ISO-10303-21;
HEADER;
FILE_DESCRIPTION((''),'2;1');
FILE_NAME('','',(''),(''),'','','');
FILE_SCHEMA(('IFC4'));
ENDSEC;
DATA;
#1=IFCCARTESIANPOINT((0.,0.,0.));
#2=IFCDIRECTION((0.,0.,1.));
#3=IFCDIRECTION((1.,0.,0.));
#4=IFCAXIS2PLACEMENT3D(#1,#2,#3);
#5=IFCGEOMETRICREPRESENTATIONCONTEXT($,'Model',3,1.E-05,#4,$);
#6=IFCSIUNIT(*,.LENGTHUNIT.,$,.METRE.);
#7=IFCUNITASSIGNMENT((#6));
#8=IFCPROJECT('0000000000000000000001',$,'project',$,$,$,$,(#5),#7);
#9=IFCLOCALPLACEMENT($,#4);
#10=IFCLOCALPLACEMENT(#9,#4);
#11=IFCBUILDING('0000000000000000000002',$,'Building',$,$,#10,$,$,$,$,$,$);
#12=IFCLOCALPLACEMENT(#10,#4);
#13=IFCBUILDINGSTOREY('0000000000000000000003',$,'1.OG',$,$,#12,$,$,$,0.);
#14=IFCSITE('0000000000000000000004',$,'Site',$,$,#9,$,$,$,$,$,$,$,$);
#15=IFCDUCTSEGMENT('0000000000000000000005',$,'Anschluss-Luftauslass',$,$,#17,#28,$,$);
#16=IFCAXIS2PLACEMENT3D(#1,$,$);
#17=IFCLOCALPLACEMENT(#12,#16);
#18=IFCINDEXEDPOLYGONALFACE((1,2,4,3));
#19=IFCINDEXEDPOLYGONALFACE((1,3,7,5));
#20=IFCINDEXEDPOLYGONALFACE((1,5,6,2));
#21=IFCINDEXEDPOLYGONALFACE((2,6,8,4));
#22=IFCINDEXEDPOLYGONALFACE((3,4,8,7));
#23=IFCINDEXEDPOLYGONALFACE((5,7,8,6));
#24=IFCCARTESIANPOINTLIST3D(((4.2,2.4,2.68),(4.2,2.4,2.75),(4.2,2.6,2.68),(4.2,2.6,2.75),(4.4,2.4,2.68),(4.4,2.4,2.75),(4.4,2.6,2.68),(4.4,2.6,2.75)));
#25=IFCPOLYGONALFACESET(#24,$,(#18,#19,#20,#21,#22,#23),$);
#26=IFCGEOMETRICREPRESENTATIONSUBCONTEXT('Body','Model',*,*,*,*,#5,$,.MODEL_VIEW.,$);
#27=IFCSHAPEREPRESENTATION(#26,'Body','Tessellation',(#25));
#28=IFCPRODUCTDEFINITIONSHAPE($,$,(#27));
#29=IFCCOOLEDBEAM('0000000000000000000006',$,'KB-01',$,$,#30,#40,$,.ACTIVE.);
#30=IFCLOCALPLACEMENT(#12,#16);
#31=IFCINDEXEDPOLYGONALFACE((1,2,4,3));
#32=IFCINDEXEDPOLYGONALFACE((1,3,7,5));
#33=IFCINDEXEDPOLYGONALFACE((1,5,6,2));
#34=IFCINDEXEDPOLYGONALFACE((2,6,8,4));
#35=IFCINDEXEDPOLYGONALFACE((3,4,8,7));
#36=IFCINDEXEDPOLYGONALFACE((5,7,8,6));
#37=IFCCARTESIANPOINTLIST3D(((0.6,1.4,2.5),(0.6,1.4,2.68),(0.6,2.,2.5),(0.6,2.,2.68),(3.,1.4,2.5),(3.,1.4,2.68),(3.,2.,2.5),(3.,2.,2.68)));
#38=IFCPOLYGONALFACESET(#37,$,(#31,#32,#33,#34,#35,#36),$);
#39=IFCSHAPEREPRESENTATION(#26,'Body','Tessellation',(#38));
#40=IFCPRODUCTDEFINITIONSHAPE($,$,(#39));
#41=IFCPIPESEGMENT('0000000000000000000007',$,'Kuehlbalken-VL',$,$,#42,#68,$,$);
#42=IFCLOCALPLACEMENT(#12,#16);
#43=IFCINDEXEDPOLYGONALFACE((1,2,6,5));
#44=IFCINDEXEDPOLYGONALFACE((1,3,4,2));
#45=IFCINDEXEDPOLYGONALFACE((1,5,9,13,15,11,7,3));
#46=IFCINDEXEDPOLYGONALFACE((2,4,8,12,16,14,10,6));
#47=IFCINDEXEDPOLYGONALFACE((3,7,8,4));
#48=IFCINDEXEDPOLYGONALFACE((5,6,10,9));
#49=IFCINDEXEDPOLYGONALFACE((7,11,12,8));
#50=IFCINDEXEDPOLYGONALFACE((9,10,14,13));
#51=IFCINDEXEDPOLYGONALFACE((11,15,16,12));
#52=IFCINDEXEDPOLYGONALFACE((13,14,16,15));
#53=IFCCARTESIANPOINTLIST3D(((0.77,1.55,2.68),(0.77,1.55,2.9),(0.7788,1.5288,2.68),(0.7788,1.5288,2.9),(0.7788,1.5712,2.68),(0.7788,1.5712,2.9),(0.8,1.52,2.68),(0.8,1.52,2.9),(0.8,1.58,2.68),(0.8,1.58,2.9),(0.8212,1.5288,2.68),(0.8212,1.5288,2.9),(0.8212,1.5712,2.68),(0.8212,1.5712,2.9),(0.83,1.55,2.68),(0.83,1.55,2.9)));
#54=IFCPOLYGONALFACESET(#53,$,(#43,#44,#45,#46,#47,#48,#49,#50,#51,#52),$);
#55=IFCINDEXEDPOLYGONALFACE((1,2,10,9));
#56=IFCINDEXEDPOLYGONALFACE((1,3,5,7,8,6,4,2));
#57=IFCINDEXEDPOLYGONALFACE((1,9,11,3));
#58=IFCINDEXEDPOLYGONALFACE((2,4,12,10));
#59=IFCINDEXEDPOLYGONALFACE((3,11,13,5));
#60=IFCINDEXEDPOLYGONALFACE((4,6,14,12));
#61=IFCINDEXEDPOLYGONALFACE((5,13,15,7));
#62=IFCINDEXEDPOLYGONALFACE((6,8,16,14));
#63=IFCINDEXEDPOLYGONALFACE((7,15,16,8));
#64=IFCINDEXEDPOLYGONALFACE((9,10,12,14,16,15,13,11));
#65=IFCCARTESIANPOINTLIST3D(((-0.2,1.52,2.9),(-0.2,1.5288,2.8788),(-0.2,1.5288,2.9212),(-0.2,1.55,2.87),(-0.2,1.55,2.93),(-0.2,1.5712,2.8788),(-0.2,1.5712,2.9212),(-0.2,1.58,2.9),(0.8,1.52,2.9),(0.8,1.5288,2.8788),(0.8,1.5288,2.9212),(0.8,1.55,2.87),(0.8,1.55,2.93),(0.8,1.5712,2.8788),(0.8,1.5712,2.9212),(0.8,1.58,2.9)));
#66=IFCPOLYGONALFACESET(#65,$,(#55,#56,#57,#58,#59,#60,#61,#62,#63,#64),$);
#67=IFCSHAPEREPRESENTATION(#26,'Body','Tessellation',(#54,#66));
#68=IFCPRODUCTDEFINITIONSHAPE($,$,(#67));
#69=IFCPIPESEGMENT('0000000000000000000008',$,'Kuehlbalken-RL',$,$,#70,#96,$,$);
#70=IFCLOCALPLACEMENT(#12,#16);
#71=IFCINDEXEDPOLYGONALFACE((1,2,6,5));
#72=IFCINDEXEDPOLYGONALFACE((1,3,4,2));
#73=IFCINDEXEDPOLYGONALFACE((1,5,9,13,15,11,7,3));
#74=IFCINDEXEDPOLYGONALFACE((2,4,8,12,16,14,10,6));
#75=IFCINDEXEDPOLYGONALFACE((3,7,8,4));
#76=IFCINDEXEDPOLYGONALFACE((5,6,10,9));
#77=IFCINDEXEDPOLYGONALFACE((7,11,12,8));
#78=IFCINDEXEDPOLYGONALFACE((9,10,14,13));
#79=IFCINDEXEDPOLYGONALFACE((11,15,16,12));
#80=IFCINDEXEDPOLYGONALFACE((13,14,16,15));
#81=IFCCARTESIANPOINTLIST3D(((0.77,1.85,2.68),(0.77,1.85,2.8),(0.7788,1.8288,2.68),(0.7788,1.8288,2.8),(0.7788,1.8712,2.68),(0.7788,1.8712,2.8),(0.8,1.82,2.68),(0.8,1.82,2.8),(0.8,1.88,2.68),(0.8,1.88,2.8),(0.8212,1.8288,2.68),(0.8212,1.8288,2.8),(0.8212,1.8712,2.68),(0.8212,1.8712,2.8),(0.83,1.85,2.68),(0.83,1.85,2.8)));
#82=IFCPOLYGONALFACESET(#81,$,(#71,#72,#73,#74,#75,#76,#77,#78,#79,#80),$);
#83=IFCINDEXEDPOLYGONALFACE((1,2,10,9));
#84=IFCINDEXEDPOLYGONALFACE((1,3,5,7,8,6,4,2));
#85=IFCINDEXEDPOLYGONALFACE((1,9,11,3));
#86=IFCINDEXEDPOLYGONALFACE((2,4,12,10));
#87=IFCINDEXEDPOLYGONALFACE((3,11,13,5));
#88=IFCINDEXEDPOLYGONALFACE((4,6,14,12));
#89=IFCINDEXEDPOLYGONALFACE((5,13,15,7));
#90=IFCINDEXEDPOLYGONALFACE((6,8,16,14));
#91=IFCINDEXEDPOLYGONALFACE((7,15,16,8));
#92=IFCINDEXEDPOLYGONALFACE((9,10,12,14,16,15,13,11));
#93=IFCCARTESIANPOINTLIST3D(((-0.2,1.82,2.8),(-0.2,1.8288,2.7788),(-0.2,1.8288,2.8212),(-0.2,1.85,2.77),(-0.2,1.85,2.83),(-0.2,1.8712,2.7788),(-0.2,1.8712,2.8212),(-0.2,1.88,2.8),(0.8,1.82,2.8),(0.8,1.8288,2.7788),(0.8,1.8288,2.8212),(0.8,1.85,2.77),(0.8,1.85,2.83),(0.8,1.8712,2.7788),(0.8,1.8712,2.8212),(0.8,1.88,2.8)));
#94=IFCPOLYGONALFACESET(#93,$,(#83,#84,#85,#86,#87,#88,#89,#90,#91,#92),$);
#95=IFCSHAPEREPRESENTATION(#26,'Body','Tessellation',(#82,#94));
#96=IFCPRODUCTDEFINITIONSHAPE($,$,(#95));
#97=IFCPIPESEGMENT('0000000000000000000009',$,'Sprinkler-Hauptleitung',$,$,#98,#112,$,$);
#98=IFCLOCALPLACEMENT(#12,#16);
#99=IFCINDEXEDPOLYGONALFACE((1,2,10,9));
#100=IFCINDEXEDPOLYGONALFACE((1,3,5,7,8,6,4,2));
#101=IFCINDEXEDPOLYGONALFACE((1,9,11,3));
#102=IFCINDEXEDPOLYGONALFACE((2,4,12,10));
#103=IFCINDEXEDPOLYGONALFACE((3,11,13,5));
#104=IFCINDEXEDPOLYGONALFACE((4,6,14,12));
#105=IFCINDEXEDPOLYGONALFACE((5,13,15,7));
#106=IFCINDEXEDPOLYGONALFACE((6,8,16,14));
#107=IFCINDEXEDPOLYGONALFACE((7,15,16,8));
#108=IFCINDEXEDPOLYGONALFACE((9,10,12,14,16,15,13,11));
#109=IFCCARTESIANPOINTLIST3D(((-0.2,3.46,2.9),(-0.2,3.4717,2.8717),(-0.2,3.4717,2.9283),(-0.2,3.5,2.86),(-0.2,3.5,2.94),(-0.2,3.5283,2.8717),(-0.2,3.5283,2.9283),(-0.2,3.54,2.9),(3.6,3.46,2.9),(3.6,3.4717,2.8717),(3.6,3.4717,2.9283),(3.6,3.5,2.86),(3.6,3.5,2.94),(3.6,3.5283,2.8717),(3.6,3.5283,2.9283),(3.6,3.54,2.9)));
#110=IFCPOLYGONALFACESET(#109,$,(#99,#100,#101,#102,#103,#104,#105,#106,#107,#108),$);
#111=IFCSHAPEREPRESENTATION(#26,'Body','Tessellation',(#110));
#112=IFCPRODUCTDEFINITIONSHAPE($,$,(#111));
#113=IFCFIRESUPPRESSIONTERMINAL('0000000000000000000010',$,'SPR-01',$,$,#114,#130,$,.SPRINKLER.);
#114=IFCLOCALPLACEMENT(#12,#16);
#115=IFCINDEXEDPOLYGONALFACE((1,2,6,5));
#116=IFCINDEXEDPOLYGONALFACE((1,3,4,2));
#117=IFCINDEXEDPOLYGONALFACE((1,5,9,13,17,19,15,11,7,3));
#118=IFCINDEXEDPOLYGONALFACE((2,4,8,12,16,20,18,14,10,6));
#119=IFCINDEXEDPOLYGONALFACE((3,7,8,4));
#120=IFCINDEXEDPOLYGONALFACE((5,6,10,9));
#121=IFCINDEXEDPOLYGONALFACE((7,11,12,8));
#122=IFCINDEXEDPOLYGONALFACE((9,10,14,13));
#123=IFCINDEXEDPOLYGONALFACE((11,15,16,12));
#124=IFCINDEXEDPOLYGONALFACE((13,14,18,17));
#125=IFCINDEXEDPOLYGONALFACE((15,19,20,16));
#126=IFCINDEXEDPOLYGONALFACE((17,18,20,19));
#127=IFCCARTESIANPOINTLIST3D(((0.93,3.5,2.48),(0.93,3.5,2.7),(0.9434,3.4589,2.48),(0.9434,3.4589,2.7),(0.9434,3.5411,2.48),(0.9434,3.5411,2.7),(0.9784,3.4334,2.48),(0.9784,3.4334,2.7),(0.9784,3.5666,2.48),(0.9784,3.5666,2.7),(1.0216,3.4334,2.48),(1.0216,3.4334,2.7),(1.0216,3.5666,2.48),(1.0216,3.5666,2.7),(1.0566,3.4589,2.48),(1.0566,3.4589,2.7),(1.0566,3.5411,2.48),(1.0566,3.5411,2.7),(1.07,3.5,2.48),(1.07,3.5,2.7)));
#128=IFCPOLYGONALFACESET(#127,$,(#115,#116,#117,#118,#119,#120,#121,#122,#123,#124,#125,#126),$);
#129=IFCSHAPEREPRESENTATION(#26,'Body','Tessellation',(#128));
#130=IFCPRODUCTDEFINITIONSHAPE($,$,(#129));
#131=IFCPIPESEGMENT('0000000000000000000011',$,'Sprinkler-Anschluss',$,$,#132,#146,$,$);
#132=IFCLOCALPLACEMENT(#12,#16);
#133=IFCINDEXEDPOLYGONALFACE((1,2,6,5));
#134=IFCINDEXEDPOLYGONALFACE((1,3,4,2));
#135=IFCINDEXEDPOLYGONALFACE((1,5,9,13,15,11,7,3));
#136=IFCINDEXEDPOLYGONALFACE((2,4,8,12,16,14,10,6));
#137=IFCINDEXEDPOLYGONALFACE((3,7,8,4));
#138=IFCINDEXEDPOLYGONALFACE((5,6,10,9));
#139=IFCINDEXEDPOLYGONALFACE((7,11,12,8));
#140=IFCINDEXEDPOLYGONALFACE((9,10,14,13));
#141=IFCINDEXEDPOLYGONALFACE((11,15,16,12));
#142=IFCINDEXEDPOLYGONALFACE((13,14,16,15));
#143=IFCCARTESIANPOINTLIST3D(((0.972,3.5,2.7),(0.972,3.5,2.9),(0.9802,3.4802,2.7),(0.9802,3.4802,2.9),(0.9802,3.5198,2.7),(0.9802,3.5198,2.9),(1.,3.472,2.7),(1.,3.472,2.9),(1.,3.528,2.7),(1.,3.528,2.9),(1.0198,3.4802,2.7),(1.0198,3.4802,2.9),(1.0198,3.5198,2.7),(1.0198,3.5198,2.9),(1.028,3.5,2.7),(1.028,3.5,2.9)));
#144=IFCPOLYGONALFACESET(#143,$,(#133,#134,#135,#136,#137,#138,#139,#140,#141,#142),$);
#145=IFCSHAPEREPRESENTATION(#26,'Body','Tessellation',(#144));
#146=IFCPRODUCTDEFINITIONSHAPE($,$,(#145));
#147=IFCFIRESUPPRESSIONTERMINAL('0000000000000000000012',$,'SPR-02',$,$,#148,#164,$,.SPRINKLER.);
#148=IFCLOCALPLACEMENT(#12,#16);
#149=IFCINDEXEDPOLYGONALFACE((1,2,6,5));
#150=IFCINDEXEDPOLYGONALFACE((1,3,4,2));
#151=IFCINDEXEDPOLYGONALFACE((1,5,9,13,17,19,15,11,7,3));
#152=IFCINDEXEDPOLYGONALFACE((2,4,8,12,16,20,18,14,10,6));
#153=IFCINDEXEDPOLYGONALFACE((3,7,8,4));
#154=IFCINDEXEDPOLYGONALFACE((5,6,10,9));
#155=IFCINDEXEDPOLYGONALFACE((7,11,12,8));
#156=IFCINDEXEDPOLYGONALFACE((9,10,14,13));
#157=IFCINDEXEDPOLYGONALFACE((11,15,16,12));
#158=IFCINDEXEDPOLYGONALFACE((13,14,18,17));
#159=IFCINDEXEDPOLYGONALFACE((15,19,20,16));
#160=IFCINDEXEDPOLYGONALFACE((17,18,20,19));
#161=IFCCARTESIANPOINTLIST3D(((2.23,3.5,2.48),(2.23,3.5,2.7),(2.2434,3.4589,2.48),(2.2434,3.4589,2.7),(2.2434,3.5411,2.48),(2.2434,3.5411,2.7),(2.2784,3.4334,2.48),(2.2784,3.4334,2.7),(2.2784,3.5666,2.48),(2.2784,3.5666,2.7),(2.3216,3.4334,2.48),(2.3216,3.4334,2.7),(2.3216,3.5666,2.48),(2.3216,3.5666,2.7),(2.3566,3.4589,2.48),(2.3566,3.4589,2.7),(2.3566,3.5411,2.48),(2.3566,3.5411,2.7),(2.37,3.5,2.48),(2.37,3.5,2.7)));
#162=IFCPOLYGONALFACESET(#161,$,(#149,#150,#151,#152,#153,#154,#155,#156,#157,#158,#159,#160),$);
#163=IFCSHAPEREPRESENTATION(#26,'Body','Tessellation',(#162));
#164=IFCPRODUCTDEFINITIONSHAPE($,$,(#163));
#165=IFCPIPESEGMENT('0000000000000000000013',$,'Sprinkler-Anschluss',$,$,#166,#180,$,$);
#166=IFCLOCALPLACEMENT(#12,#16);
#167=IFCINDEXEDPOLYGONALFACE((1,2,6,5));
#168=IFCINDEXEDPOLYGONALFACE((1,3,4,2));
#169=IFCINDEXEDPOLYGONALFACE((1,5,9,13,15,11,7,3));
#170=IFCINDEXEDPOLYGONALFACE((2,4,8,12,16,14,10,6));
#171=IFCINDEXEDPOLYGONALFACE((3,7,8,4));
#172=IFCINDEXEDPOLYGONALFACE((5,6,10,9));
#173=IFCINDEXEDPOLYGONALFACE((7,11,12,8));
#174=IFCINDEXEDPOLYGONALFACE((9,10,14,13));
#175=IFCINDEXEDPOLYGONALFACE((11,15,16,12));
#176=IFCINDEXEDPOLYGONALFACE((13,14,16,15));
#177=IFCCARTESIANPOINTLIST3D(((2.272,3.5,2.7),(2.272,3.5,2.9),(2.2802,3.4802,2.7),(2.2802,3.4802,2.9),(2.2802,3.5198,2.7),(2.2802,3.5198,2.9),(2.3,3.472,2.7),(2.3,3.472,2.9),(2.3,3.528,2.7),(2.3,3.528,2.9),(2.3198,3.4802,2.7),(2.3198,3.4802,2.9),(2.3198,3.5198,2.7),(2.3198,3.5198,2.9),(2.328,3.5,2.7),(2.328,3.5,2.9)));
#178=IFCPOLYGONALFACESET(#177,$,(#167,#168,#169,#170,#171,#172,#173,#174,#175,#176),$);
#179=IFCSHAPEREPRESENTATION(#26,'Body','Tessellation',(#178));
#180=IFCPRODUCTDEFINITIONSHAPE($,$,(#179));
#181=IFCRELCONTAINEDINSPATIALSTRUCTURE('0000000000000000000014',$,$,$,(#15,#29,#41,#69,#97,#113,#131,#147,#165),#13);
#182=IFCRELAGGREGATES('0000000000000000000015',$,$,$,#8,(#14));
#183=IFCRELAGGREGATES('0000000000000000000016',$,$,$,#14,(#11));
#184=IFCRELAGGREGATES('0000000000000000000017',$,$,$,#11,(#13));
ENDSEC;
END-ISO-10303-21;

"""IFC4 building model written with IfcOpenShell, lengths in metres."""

from ifc_helpers import new_model, si_unit, frame, origin_with_axes, place, context, subcontext, project, spatial, polyline, outline, extrude, element, save


model = new_model("IFC4")

# Units and contexts
model_context = context("Model", 3, precision=1e-05, world=origin_with_axes())
body_context = subcontext(model_context, "Body", "Model", "MODEL_VIEW")
ifc_project = project(units=[si_unit("LENGTHUNIT", "METRE")], contexts=[model_context])

# Site, building, storey
site_placement = place(None, origin_with_axes())
site = spatial("IfcSite", under=ifc_project, at=site_placement, Name="Site")
building_placement = place(site_placement, origin_with_axes())
building = spatial("IfcBuilding", under=site, at=building_placement, Name="Building")
storey_placement = place(building_placement, origin_with_axes())
storey = spatial("IfcBuildingStorey", under=building, at=storey_placement, Name="1.OG", Elevation=0.0)

# Duct segment
duct_segment_1_placement = place(storey_placement, origin_with_axes())
element("IfcDuctSegment", 1, at=duct_segment_1_placement, inside=storey, Name="Anschluss-Luftauslass", context=body_context, shape_type="SweptSolid", body=[
    extrude(outline(polyline([(-0.1, -0.1, 0.0), (0.1, -0.1, 0.0), (0.1, 0.1, 0.0), (-0.1, 0.1, 0.0), (-0.1, -0.1, 0.0)])), frame((4.3, 2.5, 2.68), z_axis=(0.0, 0.0, 1.0), x_axis=(1.0, 0.0, 0.0)), (0.0, 0.0, 1.0), 0.07),
])

# Cooled beam
cooled_beam_placement = place(storey_placement, origin_with_axes())
element("IfcCooledBeam", 2, at=cooled_beam_placement, inside=storey, Name="KB-01", PredefinedType="ACTIVE", context=body_context, shape_type="SweptSolid", body=[
    extrude(outline(polyline([(0.6, 1.4, 0.0), (3.0, 1.4, 0.0), (3.0, 2.0, 0.0), (0.6, 2.0, 0.0), (0.6, 1.4, 0.0)])), frame((0.0, 0.0, 2.5), z_axis=(0.0, 0.0, 1.0), x_axis=(1.0, 0.0, 0.0)), (0.0, 0.0, 1.0), 0.18),
])

# Pipe segments
pipe_segment_1_placement = place(storey_placement, origin_with_axes())
element("IfcPipeSegment", 3, at=pipe_segment_1_placement, inside=storey, Name="Kuehlbalken-VL", context=body_context, shape_type="SweptSolid", body=[
    extrude(outline(polyline([(0.03, 0.0, 0.0), (0.0212, 0.0212, 0.0), (0.0, 0.03, 0.0), (-0.0212, 0.0212, 0.0), (-0.03, 0.0, 0.0), (-0.0212, -0.0212, 0.0), (0.0, -0.03, 0.0), (0.0212, -0.0212, 0.0), (0.03, 0.0, 0.0)])), frame((0.8, 1.55, 2.68), z_axis=(0.0, 0.0, 1.0), x_axis=(1.0, 0.0, 0.0)), (0.0, 0.0, 1.0), 0.22),
    extrude(outline(polyline([(0.03, 0.0, 0.0), (0.0212, 0.0212, 0.0), (0.0, 0.03, 0.0), (-0.0212, 0.0212, 0.0), (-0.03, 0.0, 0.0), (-0.0212, -0.0212, 0.0), (0.0, -0.03, 0.0), (0.0212, -0.0212, 0.0), (0.03, 0.0, 0.0)])), frame((0.8, 1.55, 2.9), z_axis=(-1.0, 0.0, 0.0), x_axis=(0.0, -1.0, 0.0)), (0.0, 0.0, 1.0), 1.0),
])
pipe_segment_2_placement = place(storey_placement, origin_with_axes())
element("IfcPipeSegment", 4, at=pipe_segment_2_placement, inside=storey, Name="Kuehlbalken-RL", context=body_context, shape_type="SweptSolid", body=[
    extrude(outline(polyline([(0.03, 0.0, 0.0), (0.0212, 0.0212, 0.0), (0.0, 0.03, 0.0), (-0.0212, 0.0212, 0.0), (-0.03, 0.0, 0.0), (-0.0212, -0.0212, 0.0), (0.0, -0.03, 0.0), (0.0212, -0.0212, 0.0), (0.03, 0.0, 0.0)])), frame((0.8, 1.85, 2.68), z_axis=(0.0, 0.0, 1.0), x_axis=(1.0, 0.0, 0.0)), (0.0, 0.0, 1.0), 0.12),
    extrude(outline(polyline([(0.03, 0.0, 0.0), (0.0212, 0.0212, 0.0), (0.0, 0.03, 0.0), (-0.0212, 0.0212, 0.0), (-0.03, 0.0, 0.0), (-0.0212, -0.0212, 0.0), (0.0, -0.03, 0.0), (0.0212, -0.0212, 0.0), (0.03, 0.0, 0.0)])), frame((0.8, 1.85, 2.8), z_axis=(-1.0, 0.0, 0.0), x_axis=(0.0, -1.0, 0.0)), (0.0, 0.0, 1.0), 1.0),
])
pipe_segment_3_placement = place(storey_placement, origin_with_axes())
element("IfcPipeSegment", 5, at=pipe_segment_3_placement, inside=storey, Name="Sprinkler-Hauptleitung", context=body_context, shape_type="SweptSolid", body=[
    extrude(outline(polyline([(0.04, 0.0, 0.0), (0.0283, 0.0283, 0.0), (0.0, 0.04, 0.0), (-0.0283, 0.0283, 0.0), (-0.04, 0.0, 0.0), (-0.0283, -0.0283, 0.0), (0.0, -0.04, 0.0), (0.0283, -0.0283, 0.0), (0.04, 0.0, 0.0)])), frame((-0.2, 3.5, 2.9), z_axis=(1.0, 0.0, 0.0), x_axis=(0.0, 1.0, 0.0)), (0.0, 0.0, 1.0), 3.8),
])

# Fire suppression terminal
fire_suppression_terminal_1_placement = place(storey_placement, origin_with_axes())
element("IfcFireSuppressionTerminal", 6, at=fire_suppression_terminal_1_placement, inside=storey, Name="SPR-01", PredefinedType="SPRINKLER", context=body_context, shape_type="SweptSolid", body=[
    extrude(outline(polyline([(0.07, 0.0, 0.0), (0.0566, 0.0411, 0.0), (0.0216, 0.0666, 0.0), (-0.0216, 0.0666, 0.0), (-0.0566, 0.0411, 0.0), (-0.07, 0.0, 0.0), (-0.0566, -0.0411, 0.0), (-0.0216, -0.0666, 0.0), (0.0216, -0.0666, 0.0), (0.0566, -0.0411, 0.0), (0.07, 0.0, 0.0)])), frame((1.0, 3.5, 2.48), z_axis=(0.0, 0.0, 1.0), x_axis=(1.0, 0.0, 0.0)), (0.0, 0.0, 1.0), 0.22),
])

# Pipe segment
pipe_segment_4_placement = place(storey_placement, origin_with_axes())
element("IfcPipeSegment", 7, at=pipe_segment_4_placement, inside=storey, Name="Sprinkler-Anschluss", context=body_context, shape_type="SweptSolid", body=[
    extrude(outline(polyline([(0.028, 0.0, 0.0), (0.0198, 0.0198, 0.0), (0.0, 0.028, 0.0), (-0.0198, 0.0198, 0.0), (-0.028, 0.0, 0.0), (-0.0198, -0.0198, 0.0), (0.0, -0.028, 0.0), (0.0198, -0.0198, 0.0), (0.028, 0.0, 0.0)])), frame((1.0, 3.5, 2.7), z_axis=(0.0, 0.0, 1.0), x_axis=(1.0, 0.0, 0.0)), (0.0, 0.0, 1.0), 0.2),
])

# Fire suppression terminal
fire_suppression_terminal_2_placement = place(storey_placement, origin_with_axes())
element("IfcFireSuppressionTerminal", 8, at=fire_suppression_terminal_2_placement, inside=storey, Name="SPR-02", PredefinedType="SPRINKLER", context=body_context, shape_type="SweptSolid", body=[
    extrude(outline(polyline([(0.07, 0.0, 0.0), (0.0566, 0.0411, 0.0), (0.0216, 0.0666, 0.0), (-0.0216, 0.0666, 0.0), (-0.0566, 0.0411, 0.0), (-0.07, 0.0, 0.0), (-0.0566, -0.0411, 0.0), (-0.0216, -0.0666, 0.0), (0.0216, -0.0666, 0.0), (0.0566, -0.0411, 0.0), (0.07, 0.0, 0.0)])), frame((2.3, 3.5, 2.48), z_axis=(0.0, 0.0, 1.0), x_axis=(1.0, 0.0, 0.0)), (0.0, 0.0, 1.0), 0.22),
])

# Pipe segment
pipe_segment_5_placement = place(storey_placement, origin_with_axes())
element("IfcPipeSegment", 9, at=pipe_segment_5_placement, inside=storey, Name="Sprinkler-Anschluss", context=body_context, shape_type="SweptSolid", body=[
    extrude(outline(polyline([(0.028, 0.0, 0.0), (0.0198, 0.0198, 0.0), (0.0, 0.028, 0.0), (-0.0198, 0.0198, 0.0), (-0.028, 0.0, 0.0), (-0.0198, -0.0198, 0.0), (0.0, -0.028, 0.0), (0.0198, -0.0198, 0.0), (0.028, 0.0, 0.0)])), frame((2.3, 3.5, 2.7), z_axis=(0.0, 0.0, 1.0), x_axis=(1.0, 0.0, 0.0)), (0.0, 0.0, 1.0), 0.2),
])

save(model, "model.ifc")
